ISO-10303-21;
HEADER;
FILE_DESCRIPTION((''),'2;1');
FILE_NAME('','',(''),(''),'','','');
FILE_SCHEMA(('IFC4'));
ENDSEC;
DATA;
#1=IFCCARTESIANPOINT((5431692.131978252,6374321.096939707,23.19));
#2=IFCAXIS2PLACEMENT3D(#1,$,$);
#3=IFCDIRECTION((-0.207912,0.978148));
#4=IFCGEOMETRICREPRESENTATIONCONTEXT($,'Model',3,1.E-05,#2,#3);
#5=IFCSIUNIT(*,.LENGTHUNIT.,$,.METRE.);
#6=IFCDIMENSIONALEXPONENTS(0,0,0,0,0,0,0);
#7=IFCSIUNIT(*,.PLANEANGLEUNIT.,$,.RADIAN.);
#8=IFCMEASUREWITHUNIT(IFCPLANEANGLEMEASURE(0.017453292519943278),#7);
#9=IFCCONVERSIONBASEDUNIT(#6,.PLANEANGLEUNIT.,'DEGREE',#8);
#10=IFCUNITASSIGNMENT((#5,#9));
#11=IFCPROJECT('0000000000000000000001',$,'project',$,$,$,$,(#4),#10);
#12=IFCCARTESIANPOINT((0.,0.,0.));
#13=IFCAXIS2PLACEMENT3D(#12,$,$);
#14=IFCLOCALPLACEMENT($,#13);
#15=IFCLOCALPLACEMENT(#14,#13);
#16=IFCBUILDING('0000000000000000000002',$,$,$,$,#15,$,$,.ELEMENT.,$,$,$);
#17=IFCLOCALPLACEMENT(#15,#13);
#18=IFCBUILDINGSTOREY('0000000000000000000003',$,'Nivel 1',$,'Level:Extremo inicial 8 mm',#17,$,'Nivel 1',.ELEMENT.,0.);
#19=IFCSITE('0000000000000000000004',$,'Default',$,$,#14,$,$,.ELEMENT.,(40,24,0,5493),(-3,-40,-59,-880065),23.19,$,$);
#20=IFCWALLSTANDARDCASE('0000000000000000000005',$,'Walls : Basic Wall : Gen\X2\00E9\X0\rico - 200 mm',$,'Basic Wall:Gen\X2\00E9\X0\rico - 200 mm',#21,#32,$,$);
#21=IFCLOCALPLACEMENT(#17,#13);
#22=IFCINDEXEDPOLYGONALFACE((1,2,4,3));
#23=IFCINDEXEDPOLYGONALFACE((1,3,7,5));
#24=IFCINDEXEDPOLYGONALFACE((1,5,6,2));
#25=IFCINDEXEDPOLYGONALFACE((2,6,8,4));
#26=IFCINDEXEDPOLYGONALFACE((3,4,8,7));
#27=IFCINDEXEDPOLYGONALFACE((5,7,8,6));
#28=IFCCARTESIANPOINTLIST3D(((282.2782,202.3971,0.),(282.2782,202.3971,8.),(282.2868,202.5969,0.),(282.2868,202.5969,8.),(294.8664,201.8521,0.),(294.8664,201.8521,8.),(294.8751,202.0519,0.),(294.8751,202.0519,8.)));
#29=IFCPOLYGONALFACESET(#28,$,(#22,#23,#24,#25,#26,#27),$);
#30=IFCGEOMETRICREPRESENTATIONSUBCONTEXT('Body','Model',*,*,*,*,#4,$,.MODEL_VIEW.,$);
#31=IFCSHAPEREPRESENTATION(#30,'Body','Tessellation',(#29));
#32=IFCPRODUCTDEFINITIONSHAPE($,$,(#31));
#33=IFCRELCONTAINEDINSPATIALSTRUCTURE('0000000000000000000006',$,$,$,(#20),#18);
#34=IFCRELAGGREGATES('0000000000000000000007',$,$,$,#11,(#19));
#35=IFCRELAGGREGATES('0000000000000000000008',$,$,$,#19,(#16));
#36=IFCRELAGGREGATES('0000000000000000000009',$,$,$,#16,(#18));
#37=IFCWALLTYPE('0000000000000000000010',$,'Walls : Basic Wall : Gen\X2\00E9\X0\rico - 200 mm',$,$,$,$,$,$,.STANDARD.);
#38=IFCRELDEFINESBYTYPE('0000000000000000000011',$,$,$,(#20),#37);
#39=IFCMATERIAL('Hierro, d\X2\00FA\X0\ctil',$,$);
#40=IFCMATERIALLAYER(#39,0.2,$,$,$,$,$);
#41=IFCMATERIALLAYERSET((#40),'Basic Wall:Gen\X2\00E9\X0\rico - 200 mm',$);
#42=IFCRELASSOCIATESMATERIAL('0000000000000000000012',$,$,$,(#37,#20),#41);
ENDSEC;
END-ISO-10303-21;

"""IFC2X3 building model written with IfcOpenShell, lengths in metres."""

from ifc_helpers import new_model, entity, si_unit, converted_unit, direction, frame, frame_2d, origin, place, context, subcontext, project, spatial, rectangle, extrude, material, layer, layer_set, layer_usage, type_object, element, save


model = new_model("IFC2X3")

# Units and contexts
model_context = context("Model", 3, precision=1e-05, world=frame((5431692.131978252, 6374321.096939707, 23.19)), true_north=direction((-0.207912, 0.978148)))
body_context = subcontext(model_context, "Body", "Model", "MODEL_VIEW")
ifc_project = project(units=[si_unit("LENGTHUNIT", "METRE"), converted_unit("PLANEANGLEUNIT", "DEGREE", entity("IfcPlaneAngleMeasure", 0.017453292519943278), si_unit("PLANEANGLEUNIT", "RADIAN"), dimensions=[0, 0, 0, 0, 0, 0, 0])], contexts=[model_context])

# Site, building, storey
site_placement = place(None, origin())
site = spatial("IfcSite", under=ifc_project, at=site_placement, Name="Default", CompositionType="ELEMENT", RefLatitude=(40, 24, 0, 5493), RefLongitude=(-3, -40, -59, -880065), RefElevation=23.19)
building_placement = place(site_placement, origin())
building = spatial("IfcBuilding", under=site, at=building_placement, CompositionType="ELEMENT")
storey_placement = place(building_placement, origin())
storey = spatial("IfcBuildingStorey", under=building, at=storey_placement, Name="Nivel 1", ObjectType="Level:Extremo inicial 8 mm", LongName="Nivel 1", CompositionType="ELEMENT", Elevation=0.0)

# Wall
ifc_material_1 = material(Name="Hierro, dúctil")
ifc_layer_1 = layer(ifc_material_1, 0.2)
ifc_layer_set_1 = layer_set([ifc_layer_1], Name="Basic Wall:Genérico - 200 mm")
wall_type = type_object("IfcWallType", Name="Walls : Basic Wall : Genérico - 200 mm", PredefinedType="STANDARD", material=ifc_layer_set_1)
ifc_layer_usage_1 = layer_usage(ifc_layer_set_1, "AXIS2", "NEGATIVE", 0.1)
wall_1_placement = place(storey_placement, frame((294.8707, 201.952, 0.0), z_axis=(0.0, 0.0, 1.0), x_axis=(-0.999064, 0.043255, 0.0)))
element("IfcWallStandardCase", 1, at=wall_1_placement, inside=storey, type_object=wall_type, material=ifc_layer_usage_1, Name="Walls : Basic Wall : Genérico - 200 mm", ObjectType="Basic Wall:Genérico - 200 mm", context=body_context, shape_type="SweptSolid", body=[
    extrude(rectangle(XDim=12.6, YDim=0.2, at=frame_2d((6.3, 0.0), x_axis=(-1.0, 0.0))), origin(), (0.0, 0.0, 1.0), 8.0),
])

save(model, "model.ifc")
